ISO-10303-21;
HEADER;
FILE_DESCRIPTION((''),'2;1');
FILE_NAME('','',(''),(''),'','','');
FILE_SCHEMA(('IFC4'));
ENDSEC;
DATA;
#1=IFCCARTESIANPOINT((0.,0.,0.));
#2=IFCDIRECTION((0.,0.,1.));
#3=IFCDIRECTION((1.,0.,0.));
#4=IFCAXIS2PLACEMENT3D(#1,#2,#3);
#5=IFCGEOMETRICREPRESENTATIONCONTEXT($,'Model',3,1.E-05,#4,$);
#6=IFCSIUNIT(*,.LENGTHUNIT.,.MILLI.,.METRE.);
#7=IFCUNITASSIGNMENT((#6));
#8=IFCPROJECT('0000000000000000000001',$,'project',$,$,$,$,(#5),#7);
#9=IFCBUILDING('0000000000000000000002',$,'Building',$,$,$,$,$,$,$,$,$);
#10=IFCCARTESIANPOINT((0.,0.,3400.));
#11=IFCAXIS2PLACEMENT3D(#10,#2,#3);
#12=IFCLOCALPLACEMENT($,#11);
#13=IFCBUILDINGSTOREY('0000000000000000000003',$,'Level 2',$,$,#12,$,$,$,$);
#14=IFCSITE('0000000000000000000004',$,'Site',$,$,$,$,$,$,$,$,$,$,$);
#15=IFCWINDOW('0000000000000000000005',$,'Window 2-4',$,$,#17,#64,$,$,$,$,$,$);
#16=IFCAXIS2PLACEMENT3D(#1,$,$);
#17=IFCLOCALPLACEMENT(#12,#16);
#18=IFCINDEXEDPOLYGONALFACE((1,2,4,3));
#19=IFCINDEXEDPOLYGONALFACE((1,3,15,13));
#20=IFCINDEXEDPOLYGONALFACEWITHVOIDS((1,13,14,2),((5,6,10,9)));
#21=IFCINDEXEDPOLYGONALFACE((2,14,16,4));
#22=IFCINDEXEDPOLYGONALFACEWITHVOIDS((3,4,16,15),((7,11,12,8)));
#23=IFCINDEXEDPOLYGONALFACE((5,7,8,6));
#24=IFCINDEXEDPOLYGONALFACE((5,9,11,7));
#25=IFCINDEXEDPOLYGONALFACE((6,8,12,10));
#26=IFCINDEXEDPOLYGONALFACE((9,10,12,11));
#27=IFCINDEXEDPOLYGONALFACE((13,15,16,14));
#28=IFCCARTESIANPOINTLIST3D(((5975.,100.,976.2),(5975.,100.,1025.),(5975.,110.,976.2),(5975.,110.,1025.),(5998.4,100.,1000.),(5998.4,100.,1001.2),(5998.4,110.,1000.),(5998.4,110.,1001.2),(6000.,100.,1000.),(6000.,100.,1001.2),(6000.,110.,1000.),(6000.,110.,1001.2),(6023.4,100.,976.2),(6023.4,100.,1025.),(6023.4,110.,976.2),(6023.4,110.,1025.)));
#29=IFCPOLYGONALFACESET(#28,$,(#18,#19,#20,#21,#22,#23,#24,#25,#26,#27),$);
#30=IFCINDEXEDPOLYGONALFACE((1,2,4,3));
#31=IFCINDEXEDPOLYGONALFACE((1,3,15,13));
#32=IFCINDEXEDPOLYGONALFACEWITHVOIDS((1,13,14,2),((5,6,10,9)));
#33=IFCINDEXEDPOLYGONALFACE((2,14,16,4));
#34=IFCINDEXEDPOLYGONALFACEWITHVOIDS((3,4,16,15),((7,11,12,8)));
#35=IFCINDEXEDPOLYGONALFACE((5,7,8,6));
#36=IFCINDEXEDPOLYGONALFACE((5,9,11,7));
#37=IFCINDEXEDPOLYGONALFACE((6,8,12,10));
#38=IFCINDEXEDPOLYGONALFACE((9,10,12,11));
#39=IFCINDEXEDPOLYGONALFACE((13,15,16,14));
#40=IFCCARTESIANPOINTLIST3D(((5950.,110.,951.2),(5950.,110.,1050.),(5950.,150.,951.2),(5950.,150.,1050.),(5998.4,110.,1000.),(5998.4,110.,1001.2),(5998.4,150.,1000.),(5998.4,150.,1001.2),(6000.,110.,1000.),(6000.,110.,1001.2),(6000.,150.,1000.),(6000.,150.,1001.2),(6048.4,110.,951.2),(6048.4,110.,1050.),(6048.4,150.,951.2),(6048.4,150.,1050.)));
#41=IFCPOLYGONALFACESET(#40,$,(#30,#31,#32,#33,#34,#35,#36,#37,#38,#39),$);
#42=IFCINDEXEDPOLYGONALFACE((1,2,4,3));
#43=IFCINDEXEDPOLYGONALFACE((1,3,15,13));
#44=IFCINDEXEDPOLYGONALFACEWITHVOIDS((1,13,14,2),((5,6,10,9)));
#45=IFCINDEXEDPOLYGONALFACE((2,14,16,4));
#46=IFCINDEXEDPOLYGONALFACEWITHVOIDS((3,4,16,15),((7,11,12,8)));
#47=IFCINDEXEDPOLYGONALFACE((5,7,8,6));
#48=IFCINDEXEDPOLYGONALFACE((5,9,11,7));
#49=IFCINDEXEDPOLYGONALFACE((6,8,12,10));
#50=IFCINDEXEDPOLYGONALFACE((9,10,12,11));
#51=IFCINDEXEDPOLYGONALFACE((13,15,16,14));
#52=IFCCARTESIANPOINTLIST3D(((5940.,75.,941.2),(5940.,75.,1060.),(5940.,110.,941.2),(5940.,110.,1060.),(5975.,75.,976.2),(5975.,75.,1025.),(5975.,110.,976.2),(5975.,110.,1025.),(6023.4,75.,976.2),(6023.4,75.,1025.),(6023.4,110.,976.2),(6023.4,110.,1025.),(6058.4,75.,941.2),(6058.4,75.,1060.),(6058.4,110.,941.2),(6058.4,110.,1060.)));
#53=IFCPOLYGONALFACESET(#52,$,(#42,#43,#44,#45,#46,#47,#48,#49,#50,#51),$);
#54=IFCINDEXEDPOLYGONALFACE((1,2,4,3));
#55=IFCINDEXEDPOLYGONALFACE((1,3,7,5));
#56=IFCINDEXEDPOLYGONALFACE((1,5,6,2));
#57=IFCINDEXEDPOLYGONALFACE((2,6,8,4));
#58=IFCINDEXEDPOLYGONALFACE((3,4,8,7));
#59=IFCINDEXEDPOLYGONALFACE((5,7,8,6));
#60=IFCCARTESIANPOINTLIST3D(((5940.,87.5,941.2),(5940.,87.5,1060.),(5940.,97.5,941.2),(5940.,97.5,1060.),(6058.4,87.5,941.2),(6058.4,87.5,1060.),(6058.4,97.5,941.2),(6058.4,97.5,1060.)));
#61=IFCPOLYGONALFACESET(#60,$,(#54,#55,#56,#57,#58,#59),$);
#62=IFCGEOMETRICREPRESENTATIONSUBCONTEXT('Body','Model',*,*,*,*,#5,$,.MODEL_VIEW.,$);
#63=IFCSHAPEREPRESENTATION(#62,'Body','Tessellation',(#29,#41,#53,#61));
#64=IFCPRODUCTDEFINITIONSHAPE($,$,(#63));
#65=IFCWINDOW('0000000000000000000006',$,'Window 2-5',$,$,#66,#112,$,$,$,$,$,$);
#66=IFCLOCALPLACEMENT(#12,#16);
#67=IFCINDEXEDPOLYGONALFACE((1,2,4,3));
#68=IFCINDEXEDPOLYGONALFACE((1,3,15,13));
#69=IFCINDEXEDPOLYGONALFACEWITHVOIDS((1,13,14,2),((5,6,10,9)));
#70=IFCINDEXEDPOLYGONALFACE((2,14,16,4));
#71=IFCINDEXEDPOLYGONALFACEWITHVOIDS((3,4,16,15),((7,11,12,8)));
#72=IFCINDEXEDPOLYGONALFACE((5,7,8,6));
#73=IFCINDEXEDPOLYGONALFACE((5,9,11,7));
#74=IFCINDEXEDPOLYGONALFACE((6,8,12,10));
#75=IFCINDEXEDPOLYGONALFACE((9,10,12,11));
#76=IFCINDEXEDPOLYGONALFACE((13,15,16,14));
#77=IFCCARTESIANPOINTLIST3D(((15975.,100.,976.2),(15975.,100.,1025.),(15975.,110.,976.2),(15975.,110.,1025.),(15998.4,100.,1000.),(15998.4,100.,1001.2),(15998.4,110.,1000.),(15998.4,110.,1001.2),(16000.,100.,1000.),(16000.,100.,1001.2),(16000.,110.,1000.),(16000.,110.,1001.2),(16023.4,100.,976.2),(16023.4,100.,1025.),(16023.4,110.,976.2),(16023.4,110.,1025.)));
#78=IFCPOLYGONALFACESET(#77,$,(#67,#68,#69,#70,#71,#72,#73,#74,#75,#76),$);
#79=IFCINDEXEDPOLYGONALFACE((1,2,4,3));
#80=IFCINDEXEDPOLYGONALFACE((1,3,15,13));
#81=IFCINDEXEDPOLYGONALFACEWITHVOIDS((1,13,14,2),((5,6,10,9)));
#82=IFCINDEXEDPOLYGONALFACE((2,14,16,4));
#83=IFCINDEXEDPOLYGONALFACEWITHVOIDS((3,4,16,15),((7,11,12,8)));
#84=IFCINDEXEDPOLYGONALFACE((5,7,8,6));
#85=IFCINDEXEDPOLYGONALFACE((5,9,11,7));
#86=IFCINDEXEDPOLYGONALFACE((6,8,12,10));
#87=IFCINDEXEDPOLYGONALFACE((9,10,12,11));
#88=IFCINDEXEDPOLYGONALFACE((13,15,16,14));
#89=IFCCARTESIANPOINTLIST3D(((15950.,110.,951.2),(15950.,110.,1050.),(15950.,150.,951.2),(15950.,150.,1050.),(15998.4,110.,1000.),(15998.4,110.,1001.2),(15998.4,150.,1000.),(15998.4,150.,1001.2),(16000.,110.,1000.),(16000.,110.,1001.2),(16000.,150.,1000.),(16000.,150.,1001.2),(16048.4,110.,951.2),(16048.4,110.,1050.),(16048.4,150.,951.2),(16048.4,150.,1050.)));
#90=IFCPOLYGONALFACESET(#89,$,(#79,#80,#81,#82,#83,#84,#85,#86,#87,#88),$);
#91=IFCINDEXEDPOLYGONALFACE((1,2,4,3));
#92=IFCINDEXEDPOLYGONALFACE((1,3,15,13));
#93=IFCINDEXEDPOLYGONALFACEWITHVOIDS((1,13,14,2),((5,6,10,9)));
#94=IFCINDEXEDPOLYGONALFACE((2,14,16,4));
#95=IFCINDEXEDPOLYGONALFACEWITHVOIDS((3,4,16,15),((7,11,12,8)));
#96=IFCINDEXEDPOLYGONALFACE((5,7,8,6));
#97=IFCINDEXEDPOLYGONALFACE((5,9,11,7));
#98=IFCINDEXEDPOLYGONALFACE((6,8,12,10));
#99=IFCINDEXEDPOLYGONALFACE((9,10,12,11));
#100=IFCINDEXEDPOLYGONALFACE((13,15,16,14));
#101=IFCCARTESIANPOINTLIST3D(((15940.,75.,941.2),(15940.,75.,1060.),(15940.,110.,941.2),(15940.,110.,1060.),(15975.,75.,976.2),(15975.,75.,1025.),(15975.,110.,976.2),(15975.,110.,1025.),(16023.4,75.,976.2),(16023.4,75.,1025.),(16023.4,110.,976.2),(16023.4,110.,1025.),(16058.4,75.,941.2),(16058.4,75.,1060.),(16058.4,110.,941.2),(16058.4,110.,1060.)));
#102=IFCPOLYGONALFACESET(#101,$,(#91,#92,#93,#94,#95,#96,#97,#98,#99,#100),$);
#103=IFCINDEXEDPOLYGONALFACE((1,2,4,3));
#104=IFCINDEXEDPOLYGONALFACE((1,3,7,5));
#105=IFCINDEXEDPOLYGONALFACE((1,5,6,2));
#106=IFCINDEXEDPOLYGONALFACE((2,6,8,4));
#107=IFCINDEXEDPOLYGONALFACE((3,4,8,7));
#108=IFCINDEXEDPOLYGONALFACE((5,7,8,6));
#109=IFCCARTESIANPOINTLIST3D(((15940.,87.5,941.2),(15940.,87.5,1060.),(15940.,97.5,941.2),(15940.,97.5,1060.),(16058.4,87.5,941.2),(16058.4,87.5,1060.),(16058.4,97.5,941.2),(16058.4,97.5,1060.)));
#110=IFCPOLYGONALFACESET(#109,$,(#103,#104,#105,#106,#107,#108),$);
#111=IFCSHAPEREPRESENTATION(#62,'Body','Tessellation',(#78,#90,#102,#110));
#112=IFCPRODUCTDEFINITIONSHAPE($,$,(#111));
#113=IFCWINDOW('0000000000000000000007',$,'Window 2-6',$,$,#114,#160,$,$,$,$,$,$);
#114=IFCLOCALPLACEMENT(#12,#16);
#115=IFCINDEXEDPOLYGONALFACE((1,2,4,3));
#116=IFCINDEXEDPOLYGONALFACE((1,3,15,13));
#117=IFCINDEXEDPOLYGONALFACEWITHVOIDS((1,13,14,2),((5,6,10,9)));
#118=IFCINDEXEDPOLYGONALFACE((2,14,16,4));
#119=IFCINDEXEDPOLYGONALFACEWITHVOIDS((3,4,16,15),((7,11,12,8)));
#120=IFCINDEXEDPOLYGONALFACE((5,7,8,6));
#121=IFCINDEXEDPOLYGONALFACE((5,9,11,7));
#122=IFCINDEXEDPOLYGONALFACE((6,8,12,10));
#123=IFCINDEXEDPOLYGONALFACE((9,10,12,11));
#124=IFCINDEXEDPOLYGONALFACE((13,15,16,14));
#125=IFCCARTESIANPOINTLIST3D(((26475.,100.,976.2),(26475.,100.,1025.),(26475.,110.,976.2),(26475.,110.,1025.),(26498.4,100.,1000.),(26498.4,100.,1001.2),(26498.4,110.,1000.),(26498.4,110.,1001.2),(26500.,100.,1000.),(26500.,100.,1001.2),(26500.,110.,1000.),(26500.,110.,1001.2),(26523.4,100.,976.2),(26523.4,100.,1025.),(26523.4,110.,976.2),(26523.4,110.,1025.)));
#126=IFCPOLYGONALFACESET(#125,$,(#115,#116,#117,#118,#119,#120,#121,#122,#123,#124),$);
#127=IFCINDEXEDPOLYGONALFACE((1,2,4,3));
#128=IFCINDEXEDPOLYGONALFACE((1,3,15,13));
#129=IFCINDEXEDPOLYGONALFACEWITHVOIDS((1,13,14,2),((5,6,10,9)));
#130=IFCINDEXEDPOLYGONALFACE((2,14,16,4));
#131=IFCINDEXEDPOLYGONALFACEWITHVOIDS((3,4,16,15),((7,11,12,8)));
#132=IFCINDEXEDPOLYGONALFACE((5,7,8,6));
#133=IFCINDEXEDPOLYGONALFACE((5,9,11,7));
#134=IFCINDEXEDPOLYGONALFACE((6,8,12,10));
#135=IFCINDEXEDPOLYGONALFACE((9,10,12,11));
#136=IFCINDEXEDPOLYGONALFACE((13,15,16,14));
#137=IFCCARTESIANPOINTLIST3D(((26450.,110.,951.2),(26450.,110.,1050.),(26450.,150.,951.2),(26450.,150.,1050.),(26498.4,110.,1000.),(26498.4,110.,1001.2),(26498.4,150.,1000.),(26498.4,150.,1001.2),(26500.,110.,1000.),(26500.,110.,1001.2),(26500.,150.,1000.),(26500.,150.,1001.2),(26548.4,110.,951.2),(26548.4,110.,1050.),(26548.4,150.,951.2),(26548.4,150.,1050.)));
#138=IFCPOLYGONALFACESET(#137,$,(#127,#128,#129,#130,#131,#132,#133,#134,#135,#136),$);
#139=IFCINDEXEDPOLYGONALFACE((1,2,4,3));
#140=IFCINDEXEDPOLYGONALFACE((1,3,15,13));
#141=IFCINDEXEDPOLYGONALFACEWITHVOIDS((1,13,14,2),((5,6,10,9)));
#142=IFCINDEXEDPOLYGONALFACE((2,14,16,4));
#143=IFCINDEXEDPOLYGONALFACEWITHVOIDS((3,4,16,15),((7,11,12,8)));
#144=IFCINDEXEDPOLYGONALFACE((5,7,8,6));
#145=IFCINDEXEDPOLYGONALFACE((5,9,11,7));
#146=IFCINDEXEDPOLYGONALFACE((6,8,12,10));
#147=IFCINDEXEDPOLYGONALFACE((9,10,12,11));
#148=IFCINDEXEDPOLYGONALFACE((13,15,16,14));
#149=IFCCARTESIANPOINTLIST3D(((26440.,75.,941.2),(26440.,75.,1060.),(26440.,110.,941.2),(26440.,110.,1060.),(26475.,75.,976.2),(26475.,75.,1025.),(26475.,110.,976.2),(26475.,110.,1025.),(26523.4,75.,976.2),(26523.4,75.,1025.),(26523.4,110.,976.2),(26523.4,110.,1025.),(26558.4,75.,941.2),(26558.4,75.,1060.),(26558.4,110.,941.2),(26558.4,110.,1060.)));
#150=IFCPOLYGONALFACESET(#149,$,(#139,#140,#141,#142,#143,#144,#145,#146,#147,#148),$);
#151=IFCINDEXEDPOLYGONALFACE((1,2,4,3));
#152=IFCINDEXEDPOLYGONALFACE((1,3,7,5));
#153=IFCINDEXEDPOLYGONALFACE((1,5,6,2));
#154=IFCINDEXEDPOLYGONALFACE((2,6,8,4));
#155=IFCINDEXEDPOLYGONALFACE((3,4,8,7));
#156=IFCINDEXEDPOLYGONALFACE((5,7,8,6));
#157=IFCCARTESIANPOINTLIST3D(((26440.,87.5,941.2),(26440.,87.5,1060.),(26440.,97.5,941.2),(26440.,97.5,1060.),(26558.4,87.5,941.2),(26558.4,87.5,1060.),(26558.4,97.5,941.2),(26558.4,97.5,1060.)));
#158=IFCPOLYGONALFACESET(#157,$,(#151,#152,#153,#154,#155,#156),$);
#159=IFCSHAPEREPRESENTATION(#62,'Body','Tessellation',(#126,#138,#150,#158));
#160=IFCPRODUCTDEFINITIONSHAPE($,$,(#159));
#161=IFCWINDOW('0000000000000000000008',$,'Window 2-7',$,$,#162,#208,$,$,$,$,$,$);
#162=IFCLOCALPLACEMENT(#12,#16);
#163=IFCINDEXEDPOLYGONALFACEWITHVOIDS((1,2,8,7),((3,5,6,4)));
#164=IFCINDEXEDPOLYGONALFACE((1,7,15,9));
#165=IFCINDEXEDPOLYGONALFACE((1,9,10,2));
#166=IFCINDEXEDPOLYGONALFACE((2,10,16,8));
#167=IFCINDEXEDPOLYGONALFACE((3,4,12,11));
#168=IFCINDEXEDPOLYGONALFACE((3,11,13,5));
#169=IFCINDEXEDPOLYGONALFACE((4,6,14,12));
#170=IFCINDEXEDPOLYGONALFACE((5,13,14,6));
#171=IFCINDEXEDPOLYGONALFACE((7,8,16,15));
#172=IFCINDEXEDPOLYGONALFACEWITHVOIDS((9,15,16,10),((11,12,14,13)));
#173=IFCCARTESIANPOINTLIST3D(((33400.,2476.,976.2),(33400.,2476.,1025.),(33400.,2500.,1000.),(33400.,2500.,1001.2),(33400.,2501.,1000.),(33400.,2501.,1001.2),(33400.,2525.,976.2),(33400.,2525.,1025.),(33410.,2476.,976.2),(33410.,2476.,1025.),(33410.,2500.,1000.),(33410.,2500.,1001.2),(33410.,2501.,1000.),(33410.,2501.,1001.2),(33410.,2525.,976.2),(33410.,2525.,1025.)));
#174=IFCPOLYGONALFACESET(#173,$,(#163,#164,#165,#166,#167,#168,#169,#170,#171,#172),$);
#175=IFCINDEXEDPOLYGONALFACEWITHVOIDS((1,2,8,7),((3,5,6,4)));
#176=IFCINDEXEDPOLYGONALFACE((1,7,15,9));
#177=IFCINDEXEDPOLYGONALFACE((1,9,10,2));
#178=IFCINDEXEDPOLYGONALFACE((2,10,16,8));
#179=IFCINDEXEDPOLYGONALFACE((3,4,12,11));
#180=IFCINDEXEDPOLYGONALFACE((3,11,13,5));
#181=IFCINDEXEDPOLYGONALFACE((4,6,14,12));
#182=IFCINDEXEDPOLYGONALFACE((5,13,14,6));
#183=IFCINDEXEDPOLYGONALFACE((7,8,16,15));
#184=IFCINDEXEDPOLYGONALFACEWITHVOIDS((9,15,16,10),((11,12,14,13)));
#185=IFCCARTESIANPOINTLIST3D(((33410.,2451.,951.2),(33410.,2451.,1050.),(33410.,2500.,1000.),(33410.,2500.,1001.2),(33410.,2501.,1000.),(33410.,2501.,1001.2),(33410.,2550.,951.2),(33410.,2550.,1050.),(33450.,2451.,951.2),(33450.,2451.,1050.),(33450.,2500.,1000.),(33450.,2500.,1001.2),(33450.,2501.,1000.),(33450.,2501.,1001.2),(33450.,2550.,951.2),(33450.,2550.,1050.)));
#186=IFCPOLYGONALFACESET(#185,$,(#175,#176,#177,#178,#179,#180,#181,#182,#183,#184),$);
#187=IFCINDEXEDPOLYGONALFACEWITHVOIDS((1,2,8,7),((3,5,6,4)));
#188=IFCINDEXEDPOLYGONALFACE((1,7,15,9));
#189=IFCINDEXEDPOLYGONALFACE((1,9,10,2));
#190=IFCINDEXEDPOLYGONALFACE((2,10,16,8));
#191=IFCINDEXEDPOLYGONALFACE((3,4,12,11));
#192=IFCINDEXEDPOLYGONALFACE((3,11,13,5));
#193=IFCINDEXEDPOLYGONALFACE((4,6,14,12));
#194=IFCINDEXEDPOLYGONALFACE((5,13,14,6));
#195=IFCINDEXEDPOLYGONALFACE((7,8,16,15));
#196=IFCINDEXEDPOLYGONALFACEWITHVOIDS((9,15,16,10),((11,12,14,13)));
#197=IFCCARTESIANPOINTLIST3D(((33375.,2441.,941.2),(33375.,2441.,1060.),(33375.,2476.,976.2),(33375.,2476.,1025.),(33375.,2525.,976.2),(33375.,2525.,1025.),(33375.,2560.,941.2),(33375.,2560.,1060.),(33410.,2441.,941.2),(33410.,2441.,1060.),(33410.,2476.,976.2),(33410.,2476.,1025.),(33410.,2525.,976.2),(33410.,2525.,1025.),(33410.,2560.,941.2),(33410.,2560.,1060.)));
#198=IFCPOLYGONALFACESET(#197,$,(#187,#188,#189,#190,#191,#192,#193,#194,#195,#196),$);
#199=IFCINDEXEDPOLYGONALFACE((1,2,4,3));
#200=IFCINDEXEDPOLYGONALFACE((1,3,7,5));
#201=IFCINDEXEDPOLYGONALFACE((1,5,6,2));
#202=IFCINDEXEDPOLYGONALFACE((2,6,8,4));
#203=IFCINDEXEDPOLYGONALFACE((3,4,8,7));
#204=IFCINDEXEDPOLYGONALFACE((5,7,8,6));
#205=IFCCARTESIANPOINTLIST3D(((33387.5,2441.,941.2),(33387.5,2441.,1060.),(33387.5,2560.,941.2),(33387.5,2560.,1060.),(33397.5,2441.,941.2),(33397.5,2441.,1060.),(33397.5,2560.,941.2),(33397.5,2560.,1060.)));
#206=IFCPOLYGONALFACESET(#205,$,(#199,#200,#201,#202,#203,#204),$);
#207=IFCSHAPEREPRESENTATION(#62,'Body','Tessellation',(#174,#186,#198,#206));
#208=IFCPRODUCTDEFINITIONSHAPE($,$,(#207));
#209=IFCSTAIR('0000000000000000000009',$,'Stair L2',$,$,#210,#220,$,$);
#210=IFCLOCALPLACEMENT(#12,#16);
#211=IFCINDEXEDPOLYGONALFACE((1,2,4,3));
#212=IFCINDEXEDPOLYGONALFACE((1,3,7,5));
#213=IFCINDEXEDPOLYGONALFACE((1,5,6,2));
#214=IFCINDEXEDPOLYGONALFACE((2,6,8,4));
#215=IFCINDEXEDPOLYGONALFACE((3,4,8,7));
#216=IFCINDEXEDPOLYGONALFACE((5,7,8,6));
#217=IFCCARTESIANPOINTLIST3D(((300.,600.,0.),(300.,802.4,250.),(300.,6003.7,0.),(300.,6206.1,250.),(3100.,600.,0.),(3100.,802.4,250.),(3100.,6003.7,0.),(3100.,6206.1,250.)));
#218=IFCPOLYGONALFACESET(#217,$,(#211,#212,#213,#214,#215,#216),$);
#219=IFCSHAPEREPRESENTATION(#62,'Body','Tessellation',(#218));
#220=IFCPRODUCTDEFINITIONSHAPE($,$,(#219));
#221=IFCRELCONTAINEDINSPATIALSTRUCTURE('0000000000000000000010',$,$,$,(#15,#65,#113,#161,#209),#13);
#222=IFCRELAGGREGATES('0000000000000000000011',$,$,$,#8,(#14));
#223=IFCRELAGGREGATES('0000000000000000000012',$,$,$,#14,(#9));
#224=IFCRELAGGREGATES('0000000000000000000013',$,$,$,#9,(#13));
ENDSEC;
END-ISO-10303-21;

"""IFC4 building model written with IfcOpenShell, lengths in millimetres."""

from ifc_helpers import new_model, si_unit, frame, origin_with_axes, place, context, subcontext, project, spatial, line, indexed_curve, outline, extrude, element, save


model = new_model("IFC4")

# Units and contexts
model_context = context("Model", 3, precision=1e-05, world=origin_with_axes())
body_context = subcontext(model_context, "Body", "Model", "MODEL_VIEW")
ifc_project = project(units=[si_unit("LENGTHUNIT", "METRE", prefix="MILLI")], contexts=[model_context])

# Site, building, storey
site = spatial("IfcSite", under=ifc_project, Name="Site")
building = spatial("IfcBuilding", under=site, Name="Building")
storey_placement = place(None, frame((0.0, 0.0, 3400.0), z_axis=(0.0, 0.0, 1.0), x_axis=(1.0, 0.0, 0.0)))
storey = spatial("IfcBuildingStorey", under=building, at=storey_placement, Name="Level 2")

# Windows
for number, where, z_axis, x_axis, name in (
    (1, (6000.0, 200.0, 1000.0), (0.0, 0.0, 1.0), (-1.0, 0.0, 0.0), "Window 2-4"),
    (2, (16000.0, 200.0, 1000.0), (0.0, 0.0, 1.0), (-1.0, 0.0, 0.0), "Window 2-5"),
    (3, (26500.0, 200.0, 1000.0), (0.0, 0.0, 1.0), (-1.0, 0.0, 0.0), "Window 2-6"),
):
    element("IfcWindow", number, at=place(storey_placement, frame(where, z_axis=z_axis, x_axis=x_axis)), inside=storey, Name=name, context=body_context, shape_type="SweptSolid", body=[
        extrude(outline(indexed_curve([(0.0, 0.0), (1.6, 0.0), (1.6, 1.2), (0.0, 1.2)], segments=[line(1, 2, 3, 4, 1)]), holes=[indexed_curve([(25.0, 25.0), (-23.4, 25.0), (-23.4, -23.8), (25.0, -23.8)], segments=[line(1, 2, 3, 4, 1)])]), frame((0.0, 90.0, 0.0), z_axis=(0.0, -1.0, 0.0), x_axis=(1.0, 0.0, 0.0)), (0.0, 0.0, -1.0), 10.0),
        extrude(outline(indexed_curve([(0.0, 0.0), (1.6, 0.0), (1.6, 1.2), (0.0, 1.2)], segments=[line(1, 2, 3, 4, 1)]), holes=[indexed_curve([(50.0, 50.0), (-48.4, 50.0), (-48.4, -48.8), (50.0, -48.8)], segments=[line(1, 2, 3, 4, 1)])]), frame((0.0, 50.0, 0.0), z_axis=(0.0, -1.0, 0.0), x_axis=(1.0, 0.0, 0.0)), (0.0, 0.0, -1.0), 40.0),
        extrude(outline(indexed_curve([(0.0, 0.0), (-48.4, 0.0), (-48.4, -48.8), (0.0, -48.8)], segments=[line(1, 2, 3, 4, 1)]), holes=[indexed_curve([(35.0, 35.0), (-83.4, 35.0), (-83.4, -83.8), (35.0, -83.8)], segments=[line(1, 2, 3, 4, 1)])]), frame((25.0, 90.0, 25.0), z_axis=(0.0, -1.0, 0.0), x_axis=(1.0, 0.0, 0.0)), (0.0, 0.0, -1.0), 35.0),
        extrude(outline(indexed_curve([(35.0, 35.0), (-83.4, 35.0), (-83.4, -83.8), (35.0, -83.8)], segments=[line(1, 2, 3, 4, 1)])), frame((25.0, 102.5, 25.0), z_axis=(0.0, -1.0, 0.0), x_axis=(1.0, 0.0, 0.0)), (0.0, 0.0, -1.0), 10.0),
    ])
window_placement = place(storey_placement, frame((33500.0, 2500.0, 1000.0), z_axis=(0.0, 0.0, 1.0), x_axis=(0.0, 1.0, 0.0)))
element("IfcWindow", 4, at=window_placement, inside=storey, Name="Window 2-7", context=body_context, shape_type="SweptSolid", body=[
    extrude(outline(indexed_curve([(0.0, 0.0), (1.0, 0.0), (1.0, 1.2), (0.0, 1.2)], segments=[line(1, 2, 3, 4, 1)]), holes=[indexed_curve([(25.0, 25.0), (-24.0, 25.0), (-24.0, -23.8), (25.0, -23.8)], segments=[line(1, 2, 3, 4, 1)])]), frame((0.0, 90.0, 0.0), z_axis=(0.0, -1.0, 0.0), x_axis=(1.0, 0.0, 0.0)), (0.0, 0.0, -1.0), 10.0),
    extrude(outline(indexed_curve([(0.0, 0.0), (1.0, 0.0), (1.0, 1.2), (0.0, 1.2)], segments=[line(1, 2, 3, 4, 1)]), holes=[indexed_curve([(50.0, 50.0), (-49.0, 50.0), (-49.0, -48.8), (50.0, -48.8)], segments=[line(1, 2, 3, 4, 1)])]), frame((0.0, 50.0, 0.0), z_axis=(0.0, -1.0, 0.0), x_axis=(1.0, 0.0, 0.0)), (0.0, 0.0, -1.0), 40.0),
    extrude(outline(indexed_curve([(0.0, 0.0), (-49.0, 0.0), (-49.0, -48.8), (0.0, -48.8)], segments=[line(1, 2, 3, 4, 1)]), holes=[indexed_curve([(35.0, 35.0), (-84.0, 35.0), (-84.0, -83.8), (35.0, -83.8)], segments=[line(1, 2, 3, 4, 1)])]), frame((25.0, 90.0, 25.0), z_axis=(0.0, -1.0, 0.0), x_axis=(1.0, 0.0, 0.0)), (0.0, 0.0, -1.0), 35.0),
    extrude(outline(indexed_curve([(35.0, 35.0), (-84.0, 35.0), (-84.0, -83.8), (35.0, -83.8)], segments=[line(1, 2, 3, 4, 1)])), frame((25.0, 102.5, 25.0), z_axis=(0.0, -1.0, 0.0), x_axis=(1.0, 0.0, 0.0)), (0.0, 0.0, -1.0), 10.0),
])

# Stair
stair_placement = place(storey_placement, frame((300.0, 600.0, 0.0), z_axis=(0.0, 0.0, 1.0), x_axis=(1.0, 0.0, 0.0)))
element("IfcStair", 5, at=stair_placement, inside=storey, Name="Stair L2", context=body_context, shape_type="SweptSolid", body=[
    extrude(outline(indexed_curve([(0.0, 0.0), (2800.0, 0.0), (2800.0, 5403.7), (0.0, 5403.7), (0.0, 0.0)])), None, (0.0, 0.629198, 0.777245), 321.6),
])

save(model, "model.ifc")
